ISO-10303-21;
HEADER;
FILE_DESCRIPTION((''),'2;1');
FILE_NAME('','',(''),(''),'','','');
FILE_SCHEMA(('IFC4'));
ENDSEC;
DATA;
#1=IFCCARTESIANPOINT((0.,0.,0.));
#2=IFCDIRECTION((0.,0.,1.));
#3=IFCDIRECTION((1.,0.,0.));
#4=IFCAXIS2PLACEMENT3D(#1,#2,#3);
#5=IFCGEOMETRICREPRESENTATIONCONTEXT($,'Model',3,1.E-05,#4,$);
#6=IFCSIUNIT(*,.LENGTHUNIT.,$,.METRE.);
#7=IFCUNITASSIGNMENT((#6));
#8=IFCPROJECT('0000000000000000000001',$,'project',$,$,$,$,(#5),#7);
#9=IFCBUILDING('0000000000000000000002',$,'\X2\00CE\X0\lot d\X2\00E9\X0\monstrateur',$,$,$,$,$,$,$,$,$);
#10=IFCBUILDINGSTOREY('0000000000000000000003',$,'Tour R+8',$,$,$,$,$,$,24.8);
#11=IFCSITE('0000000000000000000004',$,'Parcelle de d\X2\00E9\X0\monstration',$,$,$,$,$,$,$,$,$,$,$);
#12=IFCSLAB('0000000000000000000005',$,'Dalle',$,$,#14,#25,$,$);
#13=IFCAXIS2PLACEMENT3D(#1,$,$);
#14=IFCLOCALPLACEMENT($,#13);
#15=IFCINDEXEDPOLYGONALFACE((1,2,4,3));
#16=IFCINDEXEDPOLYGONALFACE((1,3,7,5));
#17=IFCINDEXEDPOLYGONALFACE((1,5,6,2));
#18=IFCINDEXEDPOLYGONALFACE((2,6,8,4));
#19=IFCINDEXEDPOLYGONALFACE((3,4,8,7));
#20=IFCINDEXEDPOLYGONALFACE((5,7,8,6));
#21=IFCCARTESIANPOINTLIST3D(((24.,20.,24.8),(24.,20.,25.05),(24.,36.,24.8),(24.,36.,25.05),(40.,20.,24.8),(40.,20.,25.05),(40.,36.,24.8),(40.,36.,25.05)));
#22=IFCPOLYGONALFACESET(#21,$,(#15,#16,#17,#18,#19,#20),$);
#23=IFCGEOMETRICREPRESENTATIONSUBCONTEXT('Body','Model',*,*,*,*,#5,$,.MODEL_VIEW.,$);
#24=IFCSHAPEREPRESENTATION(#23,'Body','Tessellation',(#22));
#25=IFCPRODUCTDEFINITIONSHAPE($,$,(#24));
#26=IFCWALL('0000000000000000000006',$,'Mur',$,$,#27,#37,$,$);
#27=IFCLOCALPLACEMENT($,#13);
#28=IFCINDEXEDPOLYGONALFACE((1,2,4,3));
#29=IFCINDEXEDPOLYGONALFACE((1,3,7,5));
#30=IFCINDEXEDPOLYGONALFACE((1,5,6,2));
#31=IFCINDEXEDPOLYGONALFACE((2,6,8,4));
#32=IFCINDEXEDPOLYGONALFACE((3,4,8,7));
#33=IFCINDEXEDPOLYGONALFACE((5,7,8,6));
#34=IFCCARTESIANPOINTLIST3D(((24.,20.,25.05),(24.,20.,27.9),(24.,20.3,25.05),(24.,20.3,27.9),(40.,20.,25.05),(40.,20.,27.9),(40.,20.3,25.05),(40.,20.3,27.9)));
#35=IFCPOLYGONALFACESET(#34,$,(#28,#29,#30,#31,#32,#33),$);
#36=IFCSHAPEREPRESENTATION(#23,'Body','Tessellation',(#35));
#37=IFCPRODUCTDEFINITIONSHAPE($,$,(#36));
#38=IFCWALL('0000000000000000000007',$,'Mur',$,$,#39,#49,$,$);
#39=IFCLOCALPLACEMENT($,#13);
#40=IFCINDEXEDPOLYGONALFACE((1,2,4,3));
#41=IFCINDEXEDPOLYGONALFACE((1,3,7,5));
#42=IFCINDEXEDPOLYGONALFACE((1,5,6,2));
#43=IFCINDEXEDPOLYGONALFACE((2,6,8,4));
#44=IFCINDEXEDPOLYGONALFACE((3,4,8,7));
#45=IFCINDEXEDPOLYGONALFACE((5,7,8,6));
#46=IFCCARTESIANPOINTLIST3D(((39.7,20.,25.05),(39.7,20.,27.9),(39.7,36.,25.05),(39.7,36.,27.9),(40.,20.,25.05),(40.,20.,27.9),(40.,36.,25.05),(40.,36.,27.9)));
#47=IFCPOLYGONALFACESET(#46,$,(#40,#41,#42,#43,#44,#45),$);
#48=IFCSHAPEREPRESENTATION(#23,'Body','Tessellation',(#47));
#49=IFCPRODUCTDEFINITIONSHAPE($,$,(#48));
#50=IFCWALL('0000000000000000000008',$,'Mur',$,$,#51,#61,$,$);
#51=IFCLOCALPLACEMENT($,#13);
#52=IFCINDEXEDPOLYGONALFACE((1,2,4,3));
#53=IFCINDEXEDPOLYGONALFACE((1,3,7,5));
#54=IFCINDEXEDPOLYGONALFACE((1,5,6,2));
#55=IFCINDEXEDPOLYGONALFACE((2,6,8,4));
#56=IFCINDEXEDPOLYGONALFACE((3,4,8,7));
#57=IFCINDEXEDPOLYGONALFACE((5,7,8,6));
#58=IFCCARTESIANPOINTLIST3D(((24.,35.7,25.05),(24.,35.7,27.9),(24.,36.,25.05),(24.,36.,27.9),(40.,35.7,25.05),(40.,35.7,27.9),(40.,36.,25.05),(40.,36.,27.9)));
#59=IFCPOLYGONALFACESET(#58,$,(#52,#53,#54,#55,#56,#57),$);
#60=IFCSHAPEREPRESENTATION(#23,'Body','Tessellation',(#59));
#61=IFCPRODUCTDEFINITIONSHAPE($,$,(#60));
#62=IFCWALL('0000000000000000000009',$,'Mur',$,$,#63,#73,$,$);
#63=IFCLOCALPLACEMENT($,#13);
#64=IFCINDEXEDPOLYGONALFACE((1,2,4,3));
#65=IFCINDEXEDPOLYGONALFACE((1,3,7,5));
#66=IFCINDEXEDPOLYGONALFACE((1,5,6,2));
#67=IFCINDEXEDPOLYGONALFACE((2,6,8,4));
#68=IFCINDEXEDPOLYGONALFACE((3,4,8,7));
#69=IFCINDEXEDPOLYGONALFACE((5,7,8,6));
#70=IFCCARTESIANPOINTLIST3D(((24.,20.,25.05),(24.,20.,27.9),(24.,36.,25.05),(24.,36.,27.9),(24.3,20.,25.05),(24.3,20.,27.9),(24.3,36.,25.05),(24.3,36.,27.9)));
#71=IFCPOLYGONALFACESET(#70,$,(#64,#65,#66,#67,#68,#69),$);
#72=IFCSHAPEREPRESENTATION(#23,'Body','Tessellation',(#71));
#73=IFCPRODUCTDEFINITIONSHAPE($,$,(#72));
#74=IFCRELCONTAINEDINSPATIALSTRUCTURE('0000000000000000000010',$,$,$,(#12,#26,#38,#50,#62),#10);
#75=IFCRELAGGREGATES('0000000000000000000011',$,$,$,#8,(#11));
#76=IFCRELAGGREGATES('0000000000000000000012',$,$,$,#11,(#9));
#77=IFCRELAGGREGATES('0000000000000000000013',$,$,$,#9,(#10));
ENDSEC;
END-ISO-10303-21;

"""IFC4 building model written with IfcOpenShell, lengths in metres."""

from ifc_helpers import new_model, si_unit, frame, origin_with_axes, place, context, subcontext, project, spatial, indexed_curve, outline, extrude, element, save


model = new_model("IFC4")

# Units and contexts
model_context = context("Model", 3, precision=1e-05, world=origin_with_axes())
body_context = subcontext(model_context, "Body", "Model", "MODEL_VIEW")
ifc_project = project(units=[si_unit("LENGTHUNIT", "METRE")], contexts=[model_context])

# Site, building, storey
site = spatial("IfcSite", under=ifc_project, Name="Parcelle de démonstration")
building = spatial("IfcBuilding", under=site, Name="Îlot démonstrateur")
storey = spatial("IfcBuildingStorey", under=building, Name="Tour R+8", Elevation=24.8)

# Slab
slab_placement = place(None, frame((0.0, 0.0, 24.8), z_axis=(0.0, 0.0, 1.0), x_axis=(1.0, 0.0, 0.0)))
element("IfcSlab", 1, at=slab_placement, inside=storey, Name="Dalle", context=body_context, shape_type="SweptSolid", body=[
    extrude(outline(indexed_curve([(24.0, 20.0), (40.0, 20.0), (40.0, 36.0), (24.0, 36.0)])), None, (0.0, 0.0, 1.0), 0.25),
])

# Walls
for number, where, z_axis, x_axis, name in (
    (2, (24.0, 20.0, 25.05), (0.0, 0.0, 1.0), (1.0, 0.0, 0.0), "Mur"),
    (3, (40.0, 20.0, 25.05), (0.0, 0.0, 1.0), (0.0, 1.0, 0.0), "Mur"),
    (4, (40.0, 36.0, 25.05), (0.0, 0.0, 1.0), (-1.0, 0.0, 0.0), "Mur"),
    (5, (24.0, 36.0, 25.05), (0.0, 0.0, 1.0), (0.0, -1.0, 0.0), "Mur"),
):
    element("IfcWall", number, at=place(None, frame(where, z_axis=z_axis, x_axis=x_axis)), inside=storey, Name=name, context=body_context, shape_type="SweptSolid", body=[
        extrude(outline(indexed_curve([(0.0, 0.0), (0.0, 0.3), (16.0, 0.3), (16.0, 0.0), (0.0, 0.0)], self_intersect=False)), origin_with_axes(), (0.0, 0.0, 1.0), 2.85),
    ])

save(model, "model.ifc")
